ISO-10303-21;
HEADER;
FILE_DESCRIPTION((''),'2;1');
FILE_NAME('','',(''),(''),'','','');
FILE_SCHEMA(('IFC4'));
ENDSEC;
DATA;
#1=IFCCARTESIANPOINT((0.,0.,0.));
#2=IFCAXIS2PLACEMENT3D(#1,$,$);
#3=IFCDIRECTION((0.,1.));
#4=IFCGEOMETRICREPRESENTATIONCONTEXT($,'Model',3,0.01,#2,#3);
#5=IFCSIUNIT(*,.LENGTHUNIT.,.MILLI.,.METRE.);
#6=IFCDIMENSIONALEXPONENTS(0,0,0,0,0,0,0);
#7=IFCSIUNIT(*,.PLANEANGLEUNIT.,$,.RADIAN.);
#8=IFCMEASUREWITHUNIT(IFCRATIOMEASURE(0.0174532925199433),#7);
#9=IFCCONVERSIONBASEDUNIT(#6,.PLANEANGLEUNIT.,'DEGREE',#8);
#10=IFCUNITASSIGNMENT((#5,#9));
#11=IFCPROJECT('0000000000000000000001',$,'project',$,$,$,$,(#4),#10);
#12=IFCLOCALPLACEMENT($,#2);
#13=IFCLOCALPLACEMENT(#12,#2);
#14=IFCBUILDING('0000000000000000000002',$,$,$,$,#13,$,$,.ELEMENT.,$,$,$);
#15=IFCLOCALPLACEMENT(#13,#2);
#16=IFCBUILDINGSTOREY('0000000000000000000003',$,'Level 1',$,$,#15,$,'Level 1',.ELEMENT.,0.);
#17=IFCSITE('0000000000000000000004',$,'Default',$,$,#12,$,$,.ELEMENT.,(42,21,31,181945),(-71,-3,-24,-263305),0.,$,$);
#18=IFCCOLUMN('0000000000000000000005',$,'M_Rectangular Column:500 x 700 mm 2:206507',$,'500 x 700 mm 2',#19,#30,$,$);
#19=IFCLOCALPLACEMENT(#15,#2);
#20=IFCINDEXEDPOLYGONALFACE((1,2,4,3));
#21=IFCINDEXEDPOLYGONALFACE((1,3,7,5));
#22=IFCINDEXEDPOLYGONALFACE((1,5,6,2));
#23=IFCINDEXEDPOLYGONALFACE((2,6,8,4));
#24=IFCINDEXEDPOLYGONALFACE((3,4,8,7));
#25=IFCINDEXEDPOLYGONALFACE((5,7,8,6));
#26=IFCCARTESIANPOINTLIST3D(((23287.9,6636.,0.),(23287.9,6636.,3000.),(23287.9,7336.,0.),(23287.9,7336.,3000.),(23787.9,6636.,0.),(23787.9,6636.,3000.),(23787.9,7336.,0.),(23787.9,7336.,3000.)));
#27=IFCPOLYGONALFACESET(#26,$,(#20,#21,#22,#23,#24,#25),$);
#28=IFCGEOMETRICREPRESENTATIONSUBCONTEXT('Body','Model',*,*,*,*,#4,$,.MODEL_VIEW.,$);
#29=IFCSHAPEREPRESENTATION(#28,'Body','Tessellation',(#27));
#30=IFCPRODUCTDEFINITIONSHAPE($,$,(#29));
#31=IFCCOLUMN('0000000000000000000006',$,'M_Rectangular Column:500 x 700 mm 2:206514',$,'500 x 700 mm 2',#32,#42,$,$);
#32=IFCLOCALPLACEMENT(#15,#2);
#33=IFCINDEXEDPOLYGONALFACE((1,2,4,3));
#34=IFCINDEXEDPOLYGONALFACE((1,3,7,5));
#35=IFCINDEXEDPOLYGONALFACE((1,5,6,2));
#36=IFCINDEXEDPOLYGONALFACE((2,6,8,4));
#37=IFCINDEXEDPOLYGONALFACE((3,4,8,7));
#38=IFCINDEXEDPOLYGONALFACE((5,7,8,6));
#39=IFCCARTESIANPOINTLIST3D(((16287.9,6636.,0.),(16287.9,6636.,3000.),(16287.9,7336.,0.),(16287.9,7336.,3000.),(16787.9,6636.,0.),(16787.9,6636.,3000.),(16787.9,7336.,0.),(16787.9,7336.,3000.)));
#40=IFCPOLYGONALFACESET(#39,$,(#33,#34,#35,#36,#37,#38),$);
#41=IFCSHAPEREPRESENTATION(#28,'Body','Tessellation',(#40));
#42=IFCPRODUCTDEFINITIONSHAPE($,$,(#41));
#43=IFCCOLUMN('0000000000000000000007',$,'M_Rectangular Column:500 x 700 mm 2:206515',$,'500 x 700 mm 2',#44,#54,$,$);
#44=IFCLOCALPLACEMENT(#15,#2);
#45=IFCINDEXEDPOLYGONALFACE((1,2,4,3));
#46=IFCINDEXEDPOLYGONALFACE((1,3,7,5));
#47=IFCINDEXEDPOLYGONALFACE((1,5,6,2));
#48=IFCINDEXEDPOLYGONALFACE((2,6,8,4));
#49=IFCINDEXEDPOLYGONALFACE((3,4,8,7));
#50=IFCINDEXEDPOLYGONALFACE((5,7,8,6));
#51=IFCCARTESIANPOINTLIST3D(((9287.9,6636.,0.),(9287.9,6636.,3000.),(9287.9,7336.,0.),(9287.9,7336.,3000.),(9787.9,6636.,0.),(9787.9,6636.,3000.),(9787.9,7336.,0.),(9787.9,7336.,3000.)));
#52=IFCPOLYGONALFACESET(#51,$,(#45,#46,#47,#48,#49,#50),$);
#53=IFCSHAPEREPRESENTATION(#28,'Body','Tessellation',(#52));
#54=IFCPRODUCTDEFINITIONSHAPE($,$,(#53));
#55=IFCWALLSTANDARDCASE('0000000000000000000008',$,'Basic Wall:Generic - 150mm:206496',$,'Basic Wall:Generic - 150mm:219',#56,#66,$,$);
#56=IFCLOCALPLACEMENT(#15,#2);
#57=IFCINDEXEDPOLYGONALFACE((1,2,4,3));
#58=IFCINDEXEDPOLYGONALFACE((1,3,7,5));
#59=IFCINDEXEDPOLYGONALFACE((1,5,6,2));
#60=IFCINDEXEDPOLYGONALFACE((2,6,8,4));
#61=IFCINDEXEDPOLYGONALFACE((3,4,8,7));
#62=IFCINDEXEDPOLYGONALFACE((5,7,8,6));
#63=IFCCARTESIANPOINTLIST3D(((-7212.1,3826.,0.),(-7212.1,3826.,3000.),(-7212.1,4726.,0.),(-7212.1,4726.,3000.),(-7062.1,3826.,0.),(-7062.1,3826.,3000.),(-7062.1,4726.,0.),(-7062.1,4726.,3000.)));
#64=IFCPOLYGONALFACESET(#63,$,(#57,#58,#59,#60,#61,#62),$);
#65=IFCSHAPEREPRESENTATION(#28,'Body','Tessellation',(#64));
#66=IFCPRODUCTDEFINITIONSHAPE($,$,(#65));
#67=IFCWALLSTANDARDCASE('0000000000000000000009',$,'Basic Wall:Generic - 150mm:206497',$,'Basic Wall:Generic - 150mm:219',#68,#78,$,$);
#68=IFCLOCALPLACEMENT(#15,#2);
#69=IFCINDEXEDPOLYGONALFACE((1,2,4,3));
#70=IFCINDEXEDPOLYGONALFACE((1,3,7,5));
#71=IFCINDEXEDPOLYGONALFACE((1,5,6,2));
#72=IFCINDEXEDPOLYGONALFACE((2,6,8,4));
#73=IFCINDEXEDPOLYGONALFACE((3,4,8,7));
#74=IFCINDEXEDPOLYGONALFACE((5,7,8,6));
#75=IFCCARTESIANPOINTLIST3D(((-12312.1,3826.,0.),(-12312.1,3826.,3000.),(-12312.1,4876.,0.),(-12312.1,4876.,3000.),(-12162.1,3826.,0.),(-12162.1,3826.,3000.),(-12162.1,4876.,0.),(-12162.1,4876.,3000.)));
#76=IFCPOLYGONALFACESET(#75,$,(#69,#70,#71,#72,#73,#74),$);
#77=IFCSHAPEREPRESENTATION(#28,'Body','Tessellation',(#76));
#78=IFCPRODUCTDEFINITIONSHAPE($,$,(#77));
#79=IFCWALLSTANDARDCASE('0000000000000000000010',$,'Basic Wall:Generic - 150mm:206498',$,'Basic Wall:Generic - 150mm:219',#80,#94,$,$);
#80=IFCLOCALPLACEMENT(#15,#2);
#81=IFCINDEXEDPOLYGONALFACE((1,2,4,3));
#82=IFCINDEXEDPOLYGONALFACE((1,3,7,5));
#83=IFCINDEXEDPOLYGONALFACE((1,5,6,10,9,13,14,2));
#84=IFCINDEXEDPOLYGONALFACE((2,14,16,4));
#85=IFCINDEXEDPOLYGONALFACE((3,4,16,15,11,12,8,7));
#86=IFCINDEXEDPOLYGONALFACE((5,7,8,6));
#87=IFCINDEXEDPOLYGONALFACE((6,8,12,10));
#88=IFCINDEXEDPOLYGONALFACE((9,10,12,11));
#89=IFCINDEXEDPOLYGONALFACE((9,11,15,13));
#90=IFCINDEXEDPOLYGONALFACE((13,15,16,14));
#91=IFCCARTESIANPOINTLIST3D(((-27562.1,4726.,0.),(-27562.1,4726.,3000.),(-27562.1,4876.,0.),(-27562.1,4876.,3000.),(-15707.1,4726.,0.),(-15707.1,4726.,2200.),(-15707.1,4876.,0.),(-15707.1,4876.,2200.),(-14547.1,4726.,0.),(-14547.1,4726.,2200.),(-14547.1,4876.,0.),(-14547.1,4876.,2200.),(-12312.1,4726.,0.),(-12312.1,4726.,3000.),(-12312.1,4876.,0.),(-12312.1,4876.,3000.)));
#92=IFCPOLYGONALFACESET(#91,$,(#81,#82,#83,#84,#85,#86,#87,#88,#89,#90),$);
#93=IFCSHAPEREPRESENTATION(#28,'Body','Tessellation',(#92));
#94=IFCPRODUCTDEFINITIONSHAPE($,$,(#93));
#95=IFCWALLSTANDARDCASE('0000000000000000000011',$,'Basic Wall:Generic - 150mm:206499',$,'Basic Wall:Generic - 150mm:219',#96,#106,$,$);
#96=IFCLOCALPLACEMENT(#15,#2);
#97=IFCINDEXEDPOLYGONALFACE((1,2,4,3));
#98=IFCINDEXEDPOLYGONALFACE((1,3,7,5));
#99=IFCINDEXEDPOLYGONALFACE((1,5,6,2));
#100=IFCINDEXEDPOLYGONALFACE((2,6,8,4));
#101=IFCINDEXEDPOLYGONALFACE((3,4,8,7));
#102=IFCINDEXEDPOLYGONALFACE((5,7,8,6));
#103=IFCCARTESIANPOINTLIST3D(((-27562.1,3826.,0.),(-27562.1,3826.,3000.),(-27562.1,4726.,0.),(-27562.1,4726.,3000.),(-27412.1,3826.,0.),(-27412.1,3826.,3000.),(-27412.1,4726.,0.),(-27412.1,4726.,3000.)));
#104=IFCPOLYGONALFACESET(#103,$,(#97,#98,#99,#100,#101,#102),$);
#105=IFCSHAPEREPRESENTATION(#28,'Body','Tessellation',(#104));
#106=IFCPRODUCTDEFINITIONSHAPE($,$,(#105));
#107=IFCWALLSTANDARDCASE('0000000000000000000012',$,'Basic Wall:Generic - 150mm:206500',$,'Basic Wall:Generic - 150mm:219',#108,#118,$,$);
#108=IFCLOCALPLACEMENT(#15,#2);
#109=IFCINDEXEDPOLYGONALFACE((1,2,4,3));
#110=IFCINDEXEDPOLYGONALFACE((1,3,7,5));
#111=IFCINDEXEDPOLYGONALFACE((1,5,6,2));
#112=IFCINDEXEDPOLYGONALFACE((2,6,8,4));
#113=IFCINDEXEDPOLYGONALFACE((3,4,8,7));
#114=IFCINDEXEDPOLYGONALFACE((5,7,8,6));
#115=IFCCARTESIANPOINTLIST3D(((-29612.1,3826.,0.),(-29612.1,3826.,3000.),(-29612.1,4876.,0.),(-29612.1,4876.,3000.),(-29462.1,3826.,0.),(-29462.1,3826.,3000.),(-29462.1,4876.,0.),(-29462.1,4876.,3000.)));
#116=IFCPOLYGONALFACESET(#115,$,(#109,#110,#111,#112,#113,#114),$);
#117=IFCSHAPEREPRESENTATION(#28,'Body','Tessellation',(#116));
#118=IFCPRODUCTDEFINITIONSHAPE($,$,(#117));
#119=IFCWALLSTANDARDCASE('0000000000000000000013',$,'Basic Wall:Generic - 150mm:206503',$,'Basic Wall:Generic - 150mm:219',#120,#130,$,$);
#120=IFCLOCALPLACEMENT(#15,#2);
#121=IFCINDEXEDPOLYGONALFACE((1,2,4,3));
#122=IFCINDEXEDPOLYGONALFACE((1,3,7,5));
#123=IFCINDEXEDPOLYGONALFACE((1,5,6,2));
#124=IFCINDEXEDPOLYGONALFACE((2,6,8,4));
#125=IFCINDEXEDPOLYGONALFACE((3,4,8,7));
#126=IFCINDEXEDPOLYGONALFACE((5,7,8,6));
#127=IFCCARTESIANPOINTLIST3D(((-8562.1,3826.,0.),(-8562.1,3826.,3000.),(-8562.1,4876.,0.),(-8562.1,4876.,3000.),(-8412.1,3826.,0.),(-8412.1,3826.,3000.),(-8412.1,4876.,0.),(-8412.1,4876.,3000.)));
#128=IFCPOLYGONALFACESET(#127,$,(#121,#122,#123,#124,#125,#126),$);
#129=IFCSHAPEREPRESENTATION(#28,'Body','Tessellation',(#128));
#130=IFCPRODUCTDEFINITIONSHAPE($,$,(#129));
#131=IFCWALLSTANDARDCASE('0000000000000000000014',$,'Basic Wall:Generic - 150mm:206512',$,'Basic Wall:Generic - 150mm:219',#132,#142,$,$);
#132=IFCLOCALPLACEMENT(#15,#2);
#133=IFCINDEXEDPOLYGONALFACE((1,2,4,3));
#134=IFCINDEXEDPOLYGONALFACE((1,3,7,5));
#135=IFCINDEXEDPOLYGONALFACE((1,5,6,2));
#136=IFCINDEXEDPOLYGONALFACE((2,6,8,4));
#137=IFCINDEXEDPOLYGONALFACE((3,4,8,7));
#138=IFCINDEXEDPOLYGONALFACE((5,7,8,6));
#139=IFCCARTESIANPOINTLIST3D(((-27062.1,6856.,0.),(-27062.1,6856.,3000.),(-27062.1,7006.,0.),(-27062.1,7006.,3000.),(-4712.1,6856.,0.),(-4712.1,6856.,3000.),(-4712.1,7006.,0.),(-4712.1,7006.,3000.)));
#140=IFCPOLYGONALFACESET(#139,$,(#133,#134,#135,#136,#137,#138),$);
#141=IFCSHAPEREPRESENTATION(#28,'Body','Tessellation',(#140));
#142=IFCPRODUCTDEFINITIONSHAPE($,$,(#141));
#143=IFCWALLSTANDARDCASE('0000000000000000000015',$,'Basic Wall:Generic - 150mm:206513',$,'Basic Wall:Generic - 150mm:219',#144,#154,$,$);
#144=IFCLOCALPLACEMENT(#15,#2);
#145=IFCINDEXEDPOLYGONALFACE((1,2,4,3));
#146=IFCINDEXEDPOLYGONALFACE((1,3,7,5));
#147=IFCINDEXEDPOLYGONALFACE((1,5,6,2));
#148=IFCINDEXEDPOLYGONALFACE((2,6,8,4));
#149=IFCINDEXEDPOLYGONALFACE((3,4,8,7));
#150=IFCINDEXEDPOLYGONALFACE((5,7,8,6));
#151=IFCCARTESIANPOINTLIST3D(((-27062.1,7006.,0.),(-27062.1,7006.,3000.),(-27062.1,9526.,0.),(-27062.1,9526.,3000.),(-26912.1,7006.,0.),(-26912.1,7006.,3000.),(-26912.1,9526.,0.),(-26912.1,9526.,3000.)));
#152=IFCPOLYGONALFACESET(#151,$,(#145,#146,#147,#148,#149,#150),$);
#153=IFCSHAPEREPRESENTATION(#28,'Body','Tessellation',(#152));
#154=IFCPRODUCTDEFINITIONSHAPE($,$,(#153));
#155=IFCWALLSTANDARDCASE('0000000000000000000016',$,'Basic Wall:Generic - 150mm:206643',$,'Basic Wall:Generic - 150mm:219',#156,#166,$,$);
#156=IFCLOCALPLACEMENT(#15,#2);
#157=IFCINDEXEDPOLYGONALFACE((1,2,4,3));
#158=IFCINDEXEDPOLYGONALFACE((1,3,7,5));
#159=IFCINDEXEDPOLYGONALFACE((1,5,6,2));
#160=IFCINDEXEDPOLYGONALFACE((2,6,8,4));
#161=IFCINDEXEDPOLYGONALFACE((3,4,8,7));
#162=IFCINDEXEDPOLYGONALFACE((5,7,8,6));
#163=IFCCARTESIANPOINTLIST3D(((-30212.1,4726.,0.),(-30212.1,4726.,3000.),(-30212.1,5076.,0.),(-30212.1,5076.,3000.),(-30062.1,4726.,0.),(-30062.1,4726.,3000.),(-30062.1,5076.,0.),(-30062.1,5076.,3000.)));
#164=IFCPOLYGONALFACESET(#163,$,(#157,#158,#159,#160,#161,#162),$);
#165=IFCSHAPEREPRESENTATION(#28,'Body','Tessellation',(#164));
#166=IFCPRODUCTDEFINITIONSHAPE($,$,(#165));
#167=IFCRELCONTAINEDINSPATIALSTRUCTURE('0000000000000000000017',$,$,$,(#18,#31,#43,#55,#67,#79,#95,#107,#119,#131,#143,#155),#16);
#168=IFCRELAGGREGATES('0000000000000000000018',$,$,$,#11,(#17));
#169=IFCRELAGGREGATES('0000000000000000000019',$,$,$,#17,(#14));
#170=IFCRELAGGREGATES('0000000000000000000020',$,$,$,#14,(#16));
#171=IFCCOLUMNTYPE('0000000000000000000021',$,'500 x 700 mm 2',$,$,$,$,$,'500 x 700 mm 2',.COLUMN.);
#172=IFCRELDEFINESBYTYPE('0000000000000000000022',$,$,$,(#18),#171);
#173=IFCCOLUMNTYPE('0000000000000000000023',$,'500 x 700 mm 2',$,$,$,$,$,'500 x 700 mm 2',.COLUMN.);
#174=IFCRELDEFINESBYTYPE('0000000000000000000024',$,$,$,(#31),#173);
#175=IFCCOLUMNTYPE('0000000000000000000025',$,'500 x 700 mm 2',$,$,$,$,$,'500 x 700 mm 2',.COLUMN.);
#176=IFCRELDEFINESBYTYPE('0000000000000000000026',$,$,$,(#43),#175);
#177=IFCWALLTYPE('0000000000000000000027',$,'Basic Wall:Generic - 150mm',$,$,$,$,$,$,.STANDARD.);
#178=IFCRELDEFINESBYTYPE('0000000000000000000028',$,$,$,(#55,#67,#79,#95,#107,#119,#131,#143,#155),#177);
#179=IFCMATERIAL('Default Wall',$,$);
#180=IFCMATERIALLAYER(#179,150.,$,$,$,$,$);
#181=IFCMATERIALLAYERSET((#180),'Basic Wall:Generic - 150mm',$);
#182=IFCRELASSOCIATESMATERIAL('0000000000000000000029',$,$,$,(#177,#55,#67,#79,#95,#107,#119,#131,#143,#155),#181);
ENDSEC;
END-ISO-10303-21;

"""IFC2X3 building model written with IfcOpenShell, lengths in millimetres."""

from ifc_helpers import new_model, entity, si_unit, converted_unit, direction, frame, frame_2d, origin, origin_2d_with_axis, place, context, subcontext, project, spatial, rectangle, extrude, source, transform, mapped, material, layer, layer_set, layer_usage, type_object, type_shapes, element, save


model = new_model("IFC2X3")

# Units and contexts
model_context = context("Model", 3, precision=0.01, world=origin(), true_north=direction((0.0, 1.0)))
body_context = subcontext(model_context, "Body", "Model", "MODEL_VIEW")
ifc_project = project(units=[si_unit("LENGTHUNIT", "METRE", prefix="MILLI"), converted_unit("PLANEANGLEUNIT", "DEGREE", entity("IfcRatioMeasure", 0.0174532925199433), si_unit("PLANEANGLEUNIT", "RADIAN"), dimensions=[0, 0, 0, 0, 0, 0, 0])], contexts=[model_context])

# Site, building, storey
site_placement = place(None, origin())
site = spatial("IfcSite", under=ifc_project, at=site_placement, Name="Default", CompositionType="ELEMENT", RefLatitude=(42, 21, 31, 181945), RefLongitude=(-71, -3, -24, -263305), RefElevation=0.0)
building_placement = place(site_placement, origin())
building = spatial("IfcBuilding", under=site, at=building_placement, CompositionType="ELEMENT")
storey_placement = place(building_placement, origin())
storey = spatial("IfcBuildingStorey", under=building, at=storey_placement, Name="Level 1", LongName="Level 1", CompositionType="ELEMENT", Elevation=0.0)

# Columns
column_type_1 = type_object("IfcColumnType", Name="500 x 700 mm 2", ElementType="500 x 700 mm 2", PredefinedType="COLUMN")
shared_shape_1 = source(origin(), body_context, "Body", "SweptSolid", [
    extrude(rectangle(XDim=700.0, YDim=500.0, at=origin_2d_with_axis()), frame((23537.9, 6986.0, 0.0), z_axis=(0.0, 0.0, 1.0), x_axis=(0.0, -1.0, 0.0)), (0.0, 0.0, 1.0), 3000.0),
])
type_shapes(column_type_1, [shared_shape_1])
column_1_placement = place(storey_placement, origin())
element("IfcColumn", 1, at=column_1_placement, inside=storey, type_object=column_type_1, Name="M_Rectangular Column:500 x 700 mm 2:206507", ObjectType="500 x 700 mm 2", context=body_context, shape_type="MappedRepresentation", body=[
    mapped(shared_shape_1, transform((0.0, 0.0, 0.0), scale=1.0)),
])
column_type_2 = type_object("IfcColumnType", Name="500 x 700 mm 2", ElementType="500 x 700 mm 2", PredefinedType="COLUMN")
shared_shape_2 = source(origin(), body_context, "Body", "SweptSolid", [
    extrude(rectangle(XDim=700.0, YDim=500.0, at=frame_2d((0.0, 0.0), x_axis=(1.0, 0.0))), frame((16537.9, 6986.0, 0.0), z_axis=(0.0, 0.0, 1.0), x_axis=(0.0, -1.0, 0.0)), (0.0, 0.0, 1.0), 3000.0),
])
type_shapes(column_type_2, [shared_shape_2])
column_2_placement = place(storey_placement, origin())
element("IfcColumn", 2, at=column_2_placement, inside=storey, type_object=column_type_2, Name="M_Rectangular Column:500 x 700 mm 2:206514", ObjectType="500 x 700 mm 2", context=body_context, shape_type="MappedRepresentation", body=[
    mapped(shared_shape_2, transform((0.0, 0.0, 0.0), scale=1.0)),
])
column_type_3 = type_object("IfcColumnType", Name="500 x 700 mm 2", ElementType="500 x 700 mm 2", PredefinedType="COLUMN")
shared_shape_3 = source(origin(), body_context, "Body", "SweptSolid", [
    extrude(rectangle(XDim=700.0, YDim=500.0, at=frame_2d((0.0, 0.0), x_axis=(1.0, 0.0))), frame((9537.9, 6986.0, 0.0), z_axis=(0.0, 0.0, 1.0), x_axis=(0.0, -1.0, 0.0)), (0.0, 0.0, 1.0), 3000.0),
])
type_shapes(column_type_3, [shared_shape_3])
column_3_placement = place(storey_placement, origin())
element("IfcColumn", 3, at=column_3_placement, inside=storey, type_object=column_type_3, Name="M_Rectangular Column:500 x 700 mm 2:206515", ObjectType="500 x 700 mm 2", context=body_context, shape_type="MappedRepresentation", body=[
    mapped(shared_shape_3, transform((0.0, 0.0, 0.0), scale=1.0)),
])
ifc_material_1 = material(Name="Default Wall")

# Walls
ifc_layer_1 = layer(ifc_material_1, 150.0)
ifc_layer_set_1 = layer_set([ifc_layer_1], Name="Basic Wall:Generic - 150mm")
ifc_layer_usage_1 = layer_usage(ifc_layer_set_1, "AXIS2", "NEGATIVE", 75.0)
wall_type = type_object("IfcWallType", Name="Basic Wall:Generic - 150mm", PredefinedType="STANDARD", material=ifc_layer_set_1)
wall_1_placement = place(storey_placement, frame((-7137.1, 4726.0, 0.0), z_axis=(0.0, 0.0, 1.0), x_axis=(0.0, -1.0, 0.0)))
element("IfcWallStandardCase", 4, at=wall_1_placement, inside=storey, type_object=wall_type, material=ifc_layer_usage_1, Name="Basic Wall:Generic - 150mm:206496", ObjectType="Basic Wall:Generic - 150mm:219", context=body_context, shape_type="SweptSolid", body=[
    extrude(rectangle(XDim=900.0, YDim=150.0, at=frame_2d((450.0, 0.0), x_axis=(-1.0, 0.0))), origin(), (0.0, 0.0, 1.0), 3000.0),
])
ifc_layer_usage_2 = layer_usage(ifc_layer_set_1, "AXIS2", "NEGATIVE", 75.0)
wall_2_placement = place(storey_placement, frame((-12237.1, 3826.0, 0.0), z_axis=(0.0, 0.0, 1.0), x_axis=(0.0, 1.0, 0.0)))
element("IfcWallStandardCase", 5, at=wall_2_placement, inside=storey, type_object=wall_type, material=ifc_layer_usage_2, Name="Basic Wall:Generic - 150mm:206497", ObjectType="Basic Wall:Generic - 150mm:219", context=body_context, shape_type="SweptSolid", body=[
    extrude(rectangle(XDim=1050.0, YDim=150.0, at=frame_2d((525.0, 0.0), x_axis=(-1.0, 0.0))), origin(), (0.0, 0.0, 1.0), 3000.0),
])

# Wall, openings
ifc_layer_usage_3 = layer_usage(ifc_layer_set_1, "AXIS2", "NEGATIVE", 75.0)
wall_3_placement = place(storey_placement, frame((-12312.1, 4801.0, 0.0), z_axis=(0.0, 0.0, 1.0), x_axis=(-1.0, 0.0, 0.0)))
wall_3 = element("IfcWallStandardCase", 6, at=wall_3_placement, inside=storey, type_object=wall_type, material=ifc_layer_usage_3, Name="Basic Wall:Generic - 150mm:206498", ObjectType="Basic Wall:Generic - 150mm:219", context=body_context, shape_type="SweptSolid", body=[
    extrude(rectangle(XDim=15250.0, YDim=150.0, at=frame_2d((7625.0, 0.0), x_axis=(-1.0, 0.0))), origin(), (0.0, 0.0, 1.0), 3000.0),
])
opening_1_placement = place(wall_3_placement, origin())
element("IfcOpeningElement", 7, at=opening_1_placement, cuts=wall_3, ObjectType="Opening", context=body_context, shape_type="SweptSolid", body=[
    extrude(rectangle(XDim=2100.0, YDim=1016.0, at=frame_2d((0.0, 0.0), x_axis=(0.0, 1.0))), frame((2833.0, 75.0, 1050.0), z_axis=(0.0, -1.0, 0.0), x_axis=(1.0, 0.0, 0.0)), (0.0, 0.0, 1.0), 150.0),
])
opening_2_placement = place(wall_3_placement, frame((2235.0, -75.0, 0.0)))
element("IfcOpeningElement", 8, at=opening_2_placement, cuts=wall_3, ObjectType="Opening", context=body_context, shape_type="SweptSolid", body=[
    extrude(rectangle(XDim=2200.0, YDim=1160.0, at=frame_2d((1100.0, 580.0), x_axis=(1.0, 0.0))), frame((0.0, 0.0, 0.0), z_axis=(0.0, 1.0, 0.0), x_axis=(0.0, 0.0, 1.0)), (0.0, 0.0, 1.0), 150.0),
])

# Walls
ifc_layer_usage_4 = layer_usage(ifc_layer_set_1, "AXIS2", "NEGATIVE", 75.0)
wall_4_placement = place(storey_placement, frame((-27487.1, 4726.0, 0.0), z_axis=(0.0, 0.0, 1.0), x_axis=(0.0, -1.0, 0.0)))
element("IfcWallStandardCase", 9, at=wall_4_placement, inside=storey, type_object=wall_type, material=ifc_layer_usage_4, Name="Basic Wall:Generic - 150mm:206499", ObjectType="Basic Wall:Generic - 150mm:219", context=body_context, shape_type="SweptSolid", body=[
    extrude(rectangle(XDim=900.0, YDim=150.0, at=frame_2d((450.0, 0.0), x_axis=(-1.0, 0.0))), origin(), (0.0, 0.0, 1.0), 3000.0),
])
ifc_layer_usage_5 = layer_usage(ifc_layer_set_1, "AXIS2", "NEGATIVE", 75.0)
wall_5_placement = place(storey_placement, frame((-29537.1, 3826.0, 0.0), z_axis=(0.0, 0.0, 1.0), x_axis=(0.0, 1.0, 0.0)))
element("IfcWallStandardCase", 10, at=wall_5_placement, inside=storey, type_object=wall_type, material=ifc_layer_usage_5, Name="Basic Wall:Generic - 150mm:206500", ObjectType="Basic Wall:Generic - 150mm:219", context=body_context, shape_type="SweptSolid", body=[
    extrude(rectangle(XDim=1050.0, YDim=150.0, at=frame_2d((525.0, 0.0), x_axis=(-1.0, 0.0))), origin(), (0.0, 0.0, 1.0), 3000.0),
])
ifc_layer_usage_6 = layer_usage(ifc_layer_set_1, "AXIS2", "NEGATIVE", 75.0)
wall_6_placement = place(storey_placement, frame((-8487.1, 4876.0, 0.0), z_axis=(0.0, 0.0, 1.0), x_axis=(0.0, -1.0, 0.0)))
element("IfcWallStandardCase", 11, at=wall_6_placement, inside=storey, type_object=wall_type, material=ifc_layer_usage_6, Name="Basic Wall:Generic - 150mm:206503", ObjectType="Basic Wall:Generic - 150mm:219", context=body_context, shape_type="SweptSolid", body=[
    extrude(rectangle(XDim=1050.0, YDim=150.0, at=frame_2d((525.0, 0.0), x_axis=(-1.0, 0.0))), origin(), (0.0, 0.0, 1.0), 3000.0),
])
ifc_layer_usage_7 = layer_usage(ifc_layer_set_1, "AXIS2", "NEGATIVE", 75.0)
wall_7_placement = place(storey_placement, frame((-4712.1, 6931.0, 0.0), z_axis=(0.0, 0.0, 1.0), x_axis=(-1.0, 0.0, 0.0)))
element("IfcWallStandardCase", 12, at=wall_7_placement, inside=storey, type_object=wall_type, material=ifc_layer_usage_7, Name="Basic Wall:Generic - 150mm:206512", ObjectType="Basic Wall:Generic - 150mm:219", context=body_context, shape_type="SweptSolid", body=[
    extrude(rectangle(XDim=22350.0, YDim=150.0, at=frame_2d((11175.0, 0.0), x_axis=(-1.0, 0.0))), origin(), (0.0, 0.0, 1.0), 3000.0),
])
ifc_layer_usage_8 = layer_usage(ifc_layer_set_1, "AXIS2", "NEGATIVE", 75.0)
wall_8_placement = place(storey_placement, frame((-26987.1, 7006.0, 0.0), z_axis=(0.0, 0.0, 1.0), x_axis=(0.0, 1.0, 0.0)))
element("IfcWallStandardCase", 13, at=wall_8_placement, inside=storey, type_object=wall_type, material=ifc_layer_usage_8, Name="Basic Wall:Generic - 150mm:206513", ObjectType="Basic Wall:Generic - 150mm:219", context=body_context, shape_type="SweptSolid", body=[
    extrude(rectangle(XDim=2520.0, YDim=150.0, at=frame_2d((1260.0, 0.0), x_axis=(-1.0, 0.0))), origin(), (0.0, 0.0, 1.0), 3000.0),
])
ifc_layer_usage_9 = layer_usage(ifc_layer_set_1, "AXIS2", "NEGATIVE", 75.0)
wall_9_placement = place(storey_placement, frame((-30137.1, 5076.0, 0.0), z_axis=(0.0, 0.0, 1.0), x_axis=(0.0, -1.0, 0.0)))
element("IfcWallStandardCase", 14, at=wall_9_placement, inside=storey, type_object=wall_type, material=ifc_layer_usage_9, Name="Basic Wall:Generic - 150mm:206643", ObjectType="Basic Wall:Generic - 150mm:219", context=body_context, shape_type="SweptSolid", body=[
    extrude(rectangle(XDim=350.0, YDim=150.0, at=frame_2d((175.0, 0.0), x_axis=(-1.0, 0.0))), origin(), (0.0, 0.0, 1.0), 3000.0),
])

save(model, "model.ifc")
